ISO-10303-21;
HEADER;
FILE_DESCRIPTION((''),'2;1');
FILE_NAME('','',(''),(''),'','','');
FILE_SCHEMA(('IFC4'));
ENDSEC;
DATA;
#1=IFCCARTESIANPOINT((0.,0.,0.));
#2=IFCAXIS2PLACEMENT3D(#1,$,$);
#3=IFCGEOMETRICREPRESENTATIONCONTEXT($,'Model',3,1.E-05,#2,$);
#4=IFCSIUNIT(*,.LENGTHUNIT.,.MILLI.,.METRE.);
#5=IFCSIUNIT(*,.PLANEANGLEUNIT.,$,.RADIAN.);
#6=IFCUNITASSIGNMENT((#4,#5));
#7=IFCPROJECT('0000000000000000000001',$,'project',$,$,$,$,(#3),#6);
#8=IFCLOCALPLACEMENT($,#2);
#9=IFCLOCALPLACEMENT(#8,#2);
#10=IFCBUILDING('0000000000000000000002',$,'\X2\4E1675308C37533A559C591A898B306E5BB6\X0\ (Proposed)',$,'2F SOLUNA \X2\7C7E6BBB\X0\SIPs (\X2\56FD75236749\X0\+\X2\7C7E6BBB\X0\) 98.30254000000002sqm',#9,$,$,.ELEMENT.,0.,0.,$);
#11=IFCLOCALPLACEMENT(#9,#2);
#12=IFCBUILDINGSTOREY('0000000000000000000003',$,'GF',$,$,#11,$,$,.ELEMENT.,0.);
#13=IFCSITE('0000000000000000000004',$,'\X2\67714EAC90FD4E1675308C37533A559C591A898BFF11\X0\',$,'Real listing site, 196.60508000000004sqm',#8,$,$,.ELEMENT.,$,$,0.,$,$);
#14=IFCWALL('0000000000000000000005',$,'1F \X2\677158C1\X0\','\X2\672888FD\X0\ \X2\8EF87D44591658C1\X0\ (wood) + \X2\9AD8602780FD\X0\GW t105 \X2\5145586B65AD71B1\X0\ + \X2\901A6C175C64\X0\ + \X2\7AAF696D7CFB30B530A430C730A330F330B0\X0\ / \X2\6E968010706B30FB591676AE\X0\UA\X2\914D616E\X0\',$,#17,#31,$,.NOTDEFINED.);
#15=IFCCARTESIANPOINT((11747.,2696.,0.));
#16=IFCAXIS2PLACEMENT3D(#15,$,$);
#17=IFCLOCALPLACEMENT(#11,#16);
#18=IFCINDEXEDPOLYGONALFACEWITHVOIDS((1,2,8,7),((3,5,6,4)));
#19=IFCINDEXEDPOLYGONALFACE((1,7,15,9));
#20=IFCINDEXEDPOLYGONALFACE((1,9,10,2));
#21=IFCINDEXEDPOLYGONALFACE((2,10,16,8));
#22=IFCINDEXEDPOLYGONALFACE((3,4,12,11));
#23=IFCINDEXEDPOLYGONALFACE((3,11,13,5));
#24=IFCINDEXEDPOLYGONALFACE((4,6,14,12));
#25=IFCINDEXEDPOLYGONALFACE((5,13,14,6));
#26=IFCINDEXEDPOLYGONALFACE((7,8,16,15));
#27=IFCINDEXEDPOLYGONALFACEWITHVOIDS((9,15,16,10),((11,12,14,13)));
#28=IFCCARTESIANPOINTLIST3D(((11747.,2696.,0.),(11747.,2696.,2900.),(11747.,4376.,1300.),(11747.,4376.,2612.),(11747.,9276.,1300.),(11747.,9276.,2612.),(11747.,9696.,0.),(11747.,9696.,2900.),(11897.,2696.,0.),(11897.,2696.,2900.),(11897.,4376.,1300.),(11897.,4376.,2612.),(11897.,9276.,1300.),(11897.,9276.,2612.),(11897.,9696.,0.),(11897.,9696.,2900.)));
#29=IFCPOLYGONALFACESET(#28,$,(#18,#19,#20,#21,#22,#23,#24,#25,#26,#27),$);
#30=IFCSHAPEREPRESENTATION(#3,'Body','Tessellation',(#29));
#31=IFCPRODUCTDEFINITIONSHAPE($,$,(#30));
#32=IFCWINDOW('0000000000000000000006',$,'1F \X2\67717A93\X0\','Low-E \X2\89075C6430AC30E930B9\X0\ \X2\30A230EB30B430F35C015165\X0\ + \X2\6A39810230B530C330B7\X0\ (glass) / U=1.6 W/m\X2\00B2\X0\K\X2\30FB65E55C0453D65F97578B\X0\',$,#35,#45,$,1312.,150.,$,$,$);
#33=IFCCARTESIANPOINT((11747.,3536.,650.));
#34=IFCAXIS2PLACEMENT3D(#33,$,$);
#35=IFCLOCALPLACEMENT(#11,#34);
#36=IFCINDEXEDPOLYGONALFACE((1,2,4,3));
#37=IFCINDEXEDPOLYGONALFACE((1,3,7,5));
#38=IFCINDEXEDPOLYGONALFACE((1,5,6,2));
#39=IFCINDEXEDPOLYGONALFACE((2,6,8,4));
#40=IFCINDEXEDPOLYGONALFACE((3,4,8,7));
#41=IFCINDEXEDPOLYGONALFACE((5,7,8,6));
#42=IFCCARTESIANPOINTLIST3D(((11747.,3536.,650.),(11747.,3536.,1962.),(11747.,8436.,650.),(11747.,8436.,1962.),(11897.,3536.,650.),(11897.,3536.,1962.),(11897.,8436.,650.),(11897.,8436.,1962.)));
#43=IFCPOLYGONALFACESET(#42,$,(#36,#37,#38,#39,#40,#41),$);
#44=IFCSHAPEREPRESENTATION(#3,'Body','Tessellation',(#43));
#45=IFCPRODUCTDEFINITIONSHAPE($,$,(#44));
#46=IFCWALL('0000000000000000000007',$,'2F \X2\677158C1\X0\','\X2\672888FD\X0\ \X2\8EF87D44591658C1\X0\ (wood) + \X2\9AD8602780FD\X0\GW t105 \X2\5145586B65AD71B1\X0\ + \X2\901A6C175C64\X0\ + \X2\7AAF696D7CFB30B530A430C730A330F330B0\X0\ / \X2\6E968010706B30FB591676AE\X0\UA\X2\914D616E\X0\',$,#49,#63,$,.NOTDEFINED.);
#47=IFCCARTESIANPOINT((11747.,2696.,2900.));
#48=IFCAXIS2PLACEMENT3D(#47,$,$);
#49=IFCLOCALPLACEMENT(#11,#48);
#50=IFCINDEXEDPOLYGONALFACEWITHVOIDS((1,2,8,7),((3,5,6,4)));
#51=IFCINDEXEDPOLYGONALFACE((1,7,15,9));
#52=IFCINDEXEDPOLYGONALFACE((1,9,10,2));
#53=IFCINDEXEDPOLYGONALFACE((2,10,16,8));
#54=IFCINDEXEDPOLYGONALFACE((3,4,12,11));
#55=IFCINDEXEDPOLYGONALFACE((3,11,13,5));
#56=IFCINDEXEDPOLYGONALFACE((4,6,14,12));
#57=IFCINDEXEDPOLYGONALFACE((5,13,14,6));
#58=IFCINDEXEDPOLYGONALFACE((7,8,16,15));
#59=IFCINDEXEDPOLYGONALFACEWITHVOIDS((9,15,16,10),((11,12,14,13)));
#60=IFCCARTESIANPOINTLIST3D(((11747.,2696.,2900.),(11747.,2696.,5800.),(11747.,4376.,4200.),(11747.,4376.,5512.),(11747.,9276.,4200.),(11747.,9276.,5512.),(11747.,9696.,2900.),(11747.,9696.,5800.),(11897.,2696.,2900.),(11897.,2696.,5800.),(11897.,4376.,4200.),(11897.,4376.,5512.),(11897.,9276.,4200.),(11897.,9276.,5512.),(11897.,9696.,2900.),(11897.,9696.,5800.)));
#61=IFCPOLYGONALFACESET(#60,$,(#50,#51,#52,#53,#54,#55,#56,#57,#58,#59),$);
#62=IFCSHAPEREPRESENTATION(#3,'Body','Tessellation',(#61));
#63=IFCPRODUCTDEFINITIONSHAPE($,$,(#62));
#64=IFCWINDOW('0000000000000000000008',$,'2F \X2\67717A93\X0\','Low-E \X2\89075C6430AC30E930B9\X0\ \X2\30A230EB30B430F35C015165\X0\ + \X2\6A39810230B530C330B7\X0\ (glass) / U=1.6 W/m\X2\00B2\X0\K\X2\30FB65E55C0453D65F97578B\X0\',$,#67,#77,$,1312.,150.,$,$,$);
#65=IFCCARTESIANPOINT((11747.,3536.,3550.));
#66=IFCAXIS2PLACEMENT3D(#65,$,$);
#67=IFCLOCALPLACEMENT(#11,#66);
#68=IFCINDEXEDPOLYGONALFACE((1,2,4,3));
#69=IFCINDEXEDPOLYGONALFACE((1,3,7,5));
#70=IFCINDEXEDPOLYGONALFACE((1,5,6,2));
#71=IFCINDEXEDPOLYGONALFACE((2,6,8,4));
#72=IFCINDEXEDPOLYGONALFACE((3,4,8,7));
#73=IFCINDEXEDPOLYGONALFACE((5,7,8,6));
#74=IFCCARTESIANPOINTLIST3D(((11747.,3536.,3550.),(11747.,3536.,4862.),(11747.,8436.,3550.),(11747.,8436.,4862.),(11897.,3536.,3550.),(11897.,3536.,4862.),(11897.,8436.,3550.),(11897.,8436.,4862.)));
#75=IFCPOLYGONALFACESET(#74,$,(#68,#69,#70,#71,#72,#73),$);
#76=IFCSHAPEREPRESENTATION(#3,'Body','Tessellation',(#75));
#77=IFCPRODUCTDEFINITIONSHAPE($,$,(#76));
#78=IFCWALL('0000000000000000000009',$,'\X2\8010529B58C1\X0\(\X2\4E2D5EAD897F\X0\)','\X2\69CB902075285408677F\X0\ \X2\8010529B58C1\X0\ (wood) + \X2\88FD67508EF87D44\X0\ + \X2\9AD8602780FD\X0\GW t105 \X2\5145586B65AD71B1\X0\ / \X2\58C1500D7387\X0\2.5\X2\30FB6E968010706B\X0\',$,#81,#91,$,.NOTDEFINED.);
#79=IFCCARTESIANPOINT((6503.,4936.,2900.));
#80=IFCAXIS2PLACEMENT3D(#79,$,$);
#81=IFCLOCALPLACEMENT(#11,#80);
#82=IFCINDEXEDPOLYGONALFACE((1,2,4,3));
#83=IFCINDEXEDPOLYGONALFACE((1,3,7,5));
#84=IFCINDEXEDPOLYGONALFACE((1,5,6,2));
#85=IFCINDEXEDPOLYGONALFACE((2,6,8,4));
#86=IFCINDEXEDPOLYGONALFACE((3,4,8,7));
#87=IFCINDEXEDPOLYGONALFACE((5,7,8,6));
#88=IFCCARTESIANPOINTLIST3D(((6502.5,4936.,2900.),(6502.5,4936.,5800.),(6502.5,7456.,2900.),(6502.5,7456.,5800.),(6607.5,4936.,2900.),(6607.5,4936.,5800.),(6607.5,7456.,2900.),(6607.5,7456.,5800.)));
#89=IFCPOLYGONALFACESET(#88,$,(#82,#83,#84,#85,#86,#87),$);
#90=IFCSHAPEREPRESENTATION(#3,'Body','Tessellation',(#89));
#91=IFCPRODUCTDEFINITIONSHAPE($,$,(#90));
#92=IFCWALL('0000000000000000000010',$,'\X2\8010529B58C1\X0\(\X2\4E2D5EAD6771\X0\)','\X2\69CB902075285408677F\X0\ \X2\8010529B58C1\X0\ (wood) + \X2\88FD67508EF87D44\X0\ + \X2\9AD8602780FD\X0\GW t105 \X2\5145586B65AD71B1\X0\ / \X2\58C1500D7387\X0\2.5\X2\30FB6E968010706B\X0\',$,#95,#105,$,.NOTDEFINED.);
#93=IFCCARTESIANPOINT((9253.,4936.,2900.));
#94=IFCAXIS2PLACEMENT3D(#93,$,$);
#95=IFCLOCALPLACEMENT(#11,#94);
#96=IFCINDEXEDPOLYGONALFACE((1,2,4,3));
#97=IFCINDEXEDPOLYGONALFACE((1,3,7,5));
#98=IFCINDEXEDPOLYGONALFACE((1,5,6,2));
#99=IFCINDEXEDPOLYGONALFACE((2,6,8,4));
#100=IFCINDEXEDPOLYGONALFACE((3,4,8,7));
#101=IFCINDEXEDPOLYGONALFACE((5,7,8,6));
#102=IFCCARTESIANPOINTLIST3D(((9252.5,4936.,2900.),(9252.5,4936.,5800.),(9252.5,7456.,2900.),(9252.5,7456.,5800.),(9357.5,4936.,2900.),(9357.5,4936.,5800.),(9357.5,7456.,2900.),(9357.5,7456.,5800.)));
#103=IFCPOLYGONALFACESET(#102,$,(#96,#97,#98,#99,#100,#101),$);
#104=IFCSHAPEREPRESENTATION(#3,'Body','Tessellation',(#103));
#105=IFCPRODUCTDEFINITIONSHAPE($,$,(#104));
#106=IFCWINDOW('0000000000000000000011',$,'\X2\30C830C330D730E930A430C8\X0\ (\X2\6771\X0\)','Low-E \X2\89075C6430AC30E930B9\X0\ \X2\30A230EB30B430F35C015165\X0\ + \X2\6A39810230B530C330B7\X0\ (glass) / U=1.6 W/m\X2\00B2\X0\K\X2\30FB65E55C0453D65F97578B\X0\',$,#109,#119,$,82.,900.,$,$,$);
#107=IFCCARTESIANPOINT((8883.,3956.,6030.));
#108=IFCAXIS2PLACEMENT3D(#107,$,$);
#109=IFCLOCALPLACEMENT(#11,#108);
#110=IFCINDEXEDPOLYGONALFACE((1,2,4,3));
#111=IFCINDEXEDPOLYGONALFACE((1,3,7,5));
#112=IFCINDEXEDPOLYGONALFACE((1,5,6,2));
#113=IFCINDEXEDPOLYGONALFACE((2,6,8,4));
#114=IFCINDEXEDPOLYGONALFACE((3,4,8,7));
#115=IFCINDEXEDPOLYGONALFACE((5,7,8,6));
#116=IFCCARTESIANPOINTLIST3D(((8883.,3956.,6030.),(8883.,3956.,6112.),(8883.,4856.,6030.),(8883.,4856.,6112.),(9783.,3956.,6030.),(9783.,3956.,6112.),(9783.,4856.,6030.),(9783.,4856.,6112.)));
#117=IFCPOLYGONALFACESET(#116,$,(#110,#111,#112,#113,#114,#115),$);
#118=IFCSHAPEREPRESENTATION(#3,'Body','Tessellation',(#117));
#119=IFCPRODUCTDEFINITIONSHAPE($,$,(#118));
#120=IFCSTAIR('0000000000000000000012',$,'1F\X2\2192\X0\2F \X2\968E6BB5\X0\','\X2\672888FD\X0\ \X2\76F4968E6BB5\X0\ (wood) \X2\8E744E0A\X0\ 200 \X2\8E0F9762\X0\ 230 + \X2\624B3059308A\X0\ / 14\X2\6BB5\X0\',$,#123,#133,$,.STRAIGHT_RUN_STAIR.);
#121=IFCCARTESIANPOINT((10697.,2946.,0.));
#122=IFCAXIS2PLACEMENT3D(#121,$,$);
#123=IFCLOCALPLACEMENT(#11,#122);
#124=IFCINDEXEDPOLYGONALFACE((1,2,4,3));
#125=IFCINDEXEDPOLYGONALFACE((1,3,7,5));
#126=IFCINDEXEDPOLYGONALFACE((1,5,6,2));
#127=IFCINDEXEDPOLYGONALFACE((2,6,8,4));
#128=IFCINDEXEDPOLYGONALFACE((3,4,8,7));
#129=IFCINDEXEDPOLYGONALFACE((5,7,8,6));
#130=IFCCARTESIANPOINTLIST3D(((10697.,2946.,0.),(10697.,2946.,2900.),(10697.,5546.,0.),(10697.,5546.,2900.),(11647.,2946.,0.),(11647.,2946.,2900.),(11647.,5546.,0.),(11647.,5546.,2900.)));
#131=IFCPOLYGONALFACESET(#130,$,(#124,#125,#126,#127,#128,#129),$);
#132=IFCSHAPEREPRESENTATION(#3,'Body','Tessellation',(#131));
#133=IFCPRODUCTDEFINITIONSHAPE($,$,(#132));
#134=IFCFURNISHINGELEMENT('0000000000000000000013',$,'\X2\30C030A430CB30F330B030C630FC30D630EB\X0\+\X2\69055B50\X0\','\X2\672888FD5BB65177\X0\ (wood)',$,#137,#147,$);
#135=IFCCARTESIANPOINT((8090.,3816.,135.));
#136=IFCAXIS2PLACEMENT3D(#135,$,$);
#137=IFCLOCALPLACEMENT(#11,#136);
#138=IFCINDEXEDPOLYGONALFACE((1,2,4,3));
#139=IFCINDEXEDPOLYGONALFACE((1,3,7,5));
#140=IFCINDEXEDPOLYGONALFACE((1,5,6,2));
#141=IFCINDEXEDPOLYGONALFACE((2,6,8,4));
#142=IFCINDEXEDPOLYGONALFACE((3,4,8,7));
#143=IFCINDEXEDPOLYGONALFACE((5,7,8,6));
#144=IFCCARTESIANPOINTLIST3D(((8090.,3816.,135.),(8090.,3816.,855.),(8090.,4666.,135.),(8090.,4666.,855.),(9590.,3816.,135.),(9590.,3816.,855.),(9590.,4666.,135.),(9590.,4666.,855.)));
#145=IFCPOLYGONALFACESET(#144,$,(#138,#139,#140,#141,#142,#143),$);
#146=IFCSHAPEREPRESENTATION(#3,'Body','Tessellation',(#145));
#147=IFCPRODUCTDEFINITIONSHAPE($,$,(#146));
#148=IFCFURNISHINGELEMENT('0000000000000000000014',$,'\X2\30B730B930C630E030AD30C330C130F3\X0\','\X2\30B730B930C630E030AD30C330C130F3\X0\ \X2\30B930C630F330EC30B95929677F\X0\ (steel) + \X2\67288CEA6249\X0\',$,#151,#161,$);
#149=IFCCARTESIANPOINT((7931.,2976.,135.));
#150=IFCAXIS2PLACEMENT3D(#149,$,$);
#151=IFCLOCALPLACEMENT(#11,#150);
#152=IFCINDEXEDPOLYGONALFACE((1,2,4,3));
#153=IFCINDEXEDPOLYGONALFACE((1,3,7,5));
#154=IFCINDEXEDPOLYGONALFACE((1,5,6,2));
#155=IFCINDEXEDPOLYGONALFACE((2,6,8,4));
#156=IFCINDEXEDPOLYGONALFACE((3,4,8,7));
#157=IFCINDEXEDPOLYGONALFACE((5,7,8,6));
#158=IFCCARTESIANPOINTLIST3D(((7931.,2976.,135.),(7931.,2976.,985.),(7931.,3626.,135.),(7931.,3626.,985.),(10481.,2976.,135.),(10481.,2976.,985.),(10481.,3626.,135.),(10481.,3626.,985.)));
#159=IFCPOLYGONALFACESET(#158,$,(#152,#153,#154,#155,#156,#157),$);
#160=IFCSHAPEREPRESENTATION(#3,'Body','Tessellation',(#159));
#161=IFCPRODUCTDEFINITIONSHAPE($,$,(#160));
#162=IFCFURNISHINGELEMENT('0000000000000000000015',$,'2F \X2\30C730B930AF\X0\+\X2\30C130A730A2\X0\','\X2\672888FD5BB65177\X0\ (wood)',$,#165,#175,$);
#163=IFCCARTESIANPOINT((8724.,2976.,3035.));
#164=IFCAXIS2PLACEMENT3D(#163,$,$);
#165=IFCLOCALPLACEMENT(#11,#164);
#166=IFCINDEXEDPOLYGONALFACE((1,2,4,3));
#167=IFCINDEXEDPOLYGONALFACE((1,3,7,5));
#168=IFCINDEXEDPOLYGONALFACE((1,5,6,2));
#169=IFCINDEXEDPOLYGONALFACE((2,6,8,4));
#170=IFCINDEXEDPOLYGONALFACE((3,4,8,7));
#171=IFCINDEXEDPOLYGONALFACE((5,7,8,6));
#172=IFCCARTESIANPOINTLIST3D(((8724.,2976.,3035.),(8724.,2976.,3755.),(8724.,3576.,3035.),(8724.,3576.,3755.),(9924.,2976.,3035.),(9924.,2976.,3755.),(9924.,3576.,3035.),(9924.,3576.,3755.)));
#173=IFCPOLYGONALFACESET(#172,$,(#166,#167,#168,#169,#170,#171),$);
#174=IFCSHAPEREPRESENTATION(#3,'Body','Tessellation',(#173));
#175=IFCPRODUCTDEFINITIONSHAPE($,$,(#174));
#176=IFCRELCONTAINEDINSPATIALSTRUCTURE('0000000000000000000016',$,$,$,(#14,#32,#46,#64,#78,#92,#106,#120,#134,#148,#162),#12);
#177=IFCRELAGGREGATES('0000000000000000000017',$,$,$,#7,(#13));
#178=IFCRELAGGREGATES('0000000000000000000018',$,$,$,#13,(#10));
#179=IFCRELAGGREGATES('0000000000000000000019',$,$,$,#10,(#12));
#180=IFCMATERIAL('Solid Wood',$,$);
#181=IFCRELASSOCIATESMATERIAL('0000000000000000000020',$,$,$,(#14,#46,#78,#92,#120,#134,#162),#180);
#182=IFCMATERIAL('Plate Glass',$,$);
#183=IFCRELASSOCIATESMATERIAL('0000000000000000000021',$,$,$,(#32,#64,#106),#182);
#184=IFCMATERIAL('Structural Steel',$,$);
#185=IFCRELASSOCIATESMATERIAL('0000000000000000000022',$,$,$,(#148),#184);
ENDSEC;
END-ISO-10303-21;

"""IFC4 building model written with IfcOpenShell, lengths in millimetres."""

from ifc_helpers import new_model, si_unit, frame, frame_2d, origin, place, context, project, spatial, rectangle, extrude, material, element, fill, save


model = new_model("IFC4")

# Units and contexts
model_context = context("Model", 3, precision=1e-05, world=origin())
ifc_project = project(units=[si_unit("LENGTHUNIT", "METRE", prefix="MILLI"), si_unit("PLANEANGLEUNIT", "RADIAN")], contexts=[model_context])

# Site, building, storey
site_placement = place(None, origin())
site = spatial("IfcSite", under=ifc_project, at=site_placement, Name="東京都世田谷区喜多見１", ObjectType="Real listing site, 196.60508000000004sqm", CompositionType="ELEMENT", RefElevation=0.0)
building_placement = place(site_placement, origin())
building = spatial("IfcBuilding", under=site, at=building_placement, Name="世田谷区喜多見の家 (Proposed)", ObjectType="2F SOLUNA 籾殻SIPs (国産杉+籾殻) 98.30254000000002sqm", CompositionType="ELEMENT", ElevationOfRefHeight=0.0, ElevationOfTerrain=0.0)
storey_placement = place(building_placement, origin())
storey = spatial("IfcBuildingStorey", under=building, at=storey_placement, Name="GF", CompositionType="ELEMENT", Elevation=0.0)

# Shared definitions
ifc_material_1 = material(Name="Solid Wood")

# Wall, opening, window
wall_1_placement = place(storey_placement, frame((11747.0, 2696.0, 0.0)))
wall_1 = element("IfcWall", 1, at=wall_1_placement, inside=storey, material=ifc_material_1, Name="1F 東壁", Description="木製 軸組外壁 (wood) + 高性能GW t105 充填断熱 + 通気層 + 窯業系サイディング / 準耐火・外皮UA配慮", PredefinedType="NOTDEFINED", context=model_context, shape_type="SweptSolid", body=[
    extrude(rectangle(XDim=150.0, YDim=7000.0, at=frame_2d((75.0, 3500.0))), frame((11747.0, 2696.0, 0.0)), (0.0, 0.0, 1.0), 2900.0),
])
opening_1_placement = place(storey_placement, frame((11747.0, 3536.0, 650.0)))
opening_1 = element("IfcOpeningElement", 2, at=opening_1_placement, cuts=wall_1, PredefinedType="NOTDEFINED", context=model_context, shape_type="SweptSolid", body=[
    extrude(rectangle(XDim=150.0, YDim=4900.0, at=frame_2d((75.0, 2450.0))), frame((11747.0, 3536.0, 650.0)), (0.0, 0.0, 1.0), 1312.0),
])
ifc_material_2 = material(Name="Plate Glass")
window_1_placement = place(storey_placement, frame((11747.0, 3536.0, 650.0)))
window_1 = element("IfcWindow", 3, at=window_1_placement, inside=storey, material=ifc_material_2, Name="1F 東窓", Description="Low-E 複層ガラス アルゴン封入 + 樹脂サッシ (glass) / U=1.6 W/m²K・日射取得型", OverallHeight=1312.0, OverallWidth=150.0, context=model_context, shape_type="SweptSolid", body=[
    extrude(rectangle(XDim=150.0, YDim=4900.0, at=frame_2d((75.0, 2450.0))), frame((11747.0, 3536.0, 650.0)), (0.0, 0.0, 1.0), 1312.0),
])
fill(opening_1, window_1)

# Wall, opening, window
wall_2_placement = place(storey_placement, frame((11747.0, 2696.0, 2900.0)))
wall_2 = element("IfcWall", 4, at=wall_2_placement, inside=storey, material=ifc_material_1, Name="2F 東壁", Description="木製 軸組外壁 (wood) + 高性能GW t105 充填断熱 + 通気層 + 窯業系サイディング / 準耐火・外皮UA配慮", PredefinedType="NOTDEFINED", context=model_context, shape_type="SweptSolid", body=[
    extrude(rectangle(XDim=150.0, YDim=7000.0, at=frame_2d((75.0, 3500.0))), frame((11747.0, 2696.0, 2900.0)), (0.0, 0.0, 1.0), 2900.0),
])
opening_2_placement = place(storey_placement, frame((11747.0, 3536.0, 3550.0)))
opening_2 = element("IfcOpeningElement", 5, at=opening_2_placement, cuts=wall_2, PredefinedType="NOTDEFINED", context=model_context, shape_type="SweptSolid", body=[
    extrude(rectangle(XDim=150.0, YDim=4900.0, at=frame_2d((75.0, 2450.0))), frame((11747.0, 3536.0, 3550.0)), (0.0, 0.0, 1.0), 1312.0),
])
window_2_placement = place(storey_placement, frame((11747.0, 3536.0, 3550.0)))
window_2 = element("IfcWindow", 6, at=window_2_placement, inside=storey, material=ifc_material_2, Name="2F 東窓", Description="Low-E 複層ガラス アルゴン封入 + 樹脂サッシ (glass) / U=1.6 W/m²K・日射取得型", OverallHeight=1312.0, OverallWidth=150.0, context=model_context, shape_type="SweptSolid", body=[
    extrude(rectangle(XDim=150.0, YDim=4900.0, at=frame_2d((75.0, 2450.0))), frame((11747.0, 3536.0, 3550.0)), (0.0, 0.0, 1.0), 1312.0),
])
fill(opening_2, window_2)

# Walls
wall_3_placement = place(storey_placement, frame((6503.0, 4936.0, 2900.0)))
element("IfcWall", 7, at=wall_3_placement, inside=storey, material=ifc_material_1, Name="耐力壁(中庭西)", Description="構造用合板 耐力壁 (wood) + 製材軸組 + 高性能GW t105 充填断熱 / 壁倍率2.5・準耐火", PredefinedType="NOTDEFINED", context=model_context, shape_type="SweptSolid", body=[
    extrude(rectangle(XDim=105.0, YDim=2520.0, at=frame_2d((52.0, 1260.0))), frame((6503.0, 4936.0, 2900.0)), (0.0, 0.0, 1.0), 2900.0),
])
wall_4_placement = place(storey_placement, frame((9253.0, 4936.0, 2900.0)))
element("IfcWall", 8, at=wall_4_placement, inside=storey, material=ifc_material_1, Name="耐力壁(中庭東)", Description="構造用合板 耐力壁 (wood) + 製材軸組 + 高性能GW t105 充填断熱 / 壁倍率2.5・準耐火", PredefinedType="NOTDEFINED", context=model_context, shape_type="SweptSolid", body=[
    extrude(rectangle(XDim=105.0, YDim=2520.0, at=frame_2d((52.0, 1260.0))), frame((9253.0, 4936.0, 2900.0)), (0.0, 0.0, 1.0), 2900.0),
])

# Window
window_3_placement = place(storey_placement, frame((8883.0, 3956.0, 6030.0)))
element("IfcWindow", 9, at=window_3_placement, inside=storey, material=ifc_material_2, Name="トップライト (東)", Description="Low-E 複層ガラス アルゴン封入 + 樹脂サッシ (glass) / U=1.6 W/m²K・日射取得型", OverallHeight=82.0, OverallWidth=900.0, context=model_context, shape_type="SweptSolid", body=[
    extrude(rectangle(XDim=900.0, YDim=900.0, at=frame_2d((450.0, 450.0))), frame((8883.0, 3956.0, 6030.0)), (0.0, 0.0, 1.0), 82.0),
])

# Stair
stair_placement = place(storey_placement, frame((10697.0, 2946.0, 0.0)))
element("IfcStair", 10, at=stair_placement, inside=storey, material=ifc_material_1, Name="1F→2F 階段", Description="木製 直階段 (wood) 蹴上 200 踏面 230 + 手すり / 14段", PredefinedType="STRAIGHT_RUN_STAIR", context=model_context, shape_type="SweptSolid", body=[
    extrude(rectangle(XDim=950.0, YDim=2600.0, at=frame_2d((475.0, 1300.0))), frame((10697.0, 2946.0, 0.0)), (0.0, 0.0, 1.0), 2900.0),
])

# Furnishing elements
furnishing_1_placement = place(storey_placement, frame((8090.0, 3816.0, 135.0)))
element("IfcFurnishingElement", 11, at=furnishing_1_placement, inside=storey, material=ifc_material_1, Name="ダイニングテーブル+椅子", Description="木製家具 (wood)", context=model_context, shape_type="SweptSolid", body=[
    extrude(rectangle(XDim=1500.0, YDim=850.0, at=frame_2d((750.0, 425.0))), frame((8090.0, 3816.0, 135.0)), (0.0, 0.0, 1.0), 720.0),
])
ifc_material_3 = material(Name="Structural Steel")
furnishing_2_placement = place(storey_placement, frame((7931.0, 2976.0, 135.0)))
element("IfcFurnishingElement", 12, at=furnishing_2_placement, inside=storey, material=ifc_material_3, Name="システムキッチン", Description="システムキッチン ステンレス天板 (steel) + 木質扉", context=model_context, shape_type="SweptSolid", body=[
    extrude(rectangle(XDim=2550.0, YDim=650.0, at=frame_2d((1275.0, 325.0))), frame((7931.0, 2976.0, 135.0)), (0.0, 0.0, 1.0), 850.0),
])
furnishing_3_placement = place(storey_placement, frame((8724.0, 2976.0, 3035.0)))
element("IfcFurnishingElement", 13, at=furnishing_3_placement, inside=storey, material=ifc_material_1, Name="2F デスク+チェア", Description="木製家具 (wood)", context=model_context, shape_type="SweptSolid", body=[
    extrude(rectangle(XDim=1200.0, YDim=600.0, at=frame_2d((600.0, 300.0))), frame((8724.0, 2976.0, 3035.0)), (0.0, 0.0, 1.0), 720.0),
])

save(model, "model.ifc")
